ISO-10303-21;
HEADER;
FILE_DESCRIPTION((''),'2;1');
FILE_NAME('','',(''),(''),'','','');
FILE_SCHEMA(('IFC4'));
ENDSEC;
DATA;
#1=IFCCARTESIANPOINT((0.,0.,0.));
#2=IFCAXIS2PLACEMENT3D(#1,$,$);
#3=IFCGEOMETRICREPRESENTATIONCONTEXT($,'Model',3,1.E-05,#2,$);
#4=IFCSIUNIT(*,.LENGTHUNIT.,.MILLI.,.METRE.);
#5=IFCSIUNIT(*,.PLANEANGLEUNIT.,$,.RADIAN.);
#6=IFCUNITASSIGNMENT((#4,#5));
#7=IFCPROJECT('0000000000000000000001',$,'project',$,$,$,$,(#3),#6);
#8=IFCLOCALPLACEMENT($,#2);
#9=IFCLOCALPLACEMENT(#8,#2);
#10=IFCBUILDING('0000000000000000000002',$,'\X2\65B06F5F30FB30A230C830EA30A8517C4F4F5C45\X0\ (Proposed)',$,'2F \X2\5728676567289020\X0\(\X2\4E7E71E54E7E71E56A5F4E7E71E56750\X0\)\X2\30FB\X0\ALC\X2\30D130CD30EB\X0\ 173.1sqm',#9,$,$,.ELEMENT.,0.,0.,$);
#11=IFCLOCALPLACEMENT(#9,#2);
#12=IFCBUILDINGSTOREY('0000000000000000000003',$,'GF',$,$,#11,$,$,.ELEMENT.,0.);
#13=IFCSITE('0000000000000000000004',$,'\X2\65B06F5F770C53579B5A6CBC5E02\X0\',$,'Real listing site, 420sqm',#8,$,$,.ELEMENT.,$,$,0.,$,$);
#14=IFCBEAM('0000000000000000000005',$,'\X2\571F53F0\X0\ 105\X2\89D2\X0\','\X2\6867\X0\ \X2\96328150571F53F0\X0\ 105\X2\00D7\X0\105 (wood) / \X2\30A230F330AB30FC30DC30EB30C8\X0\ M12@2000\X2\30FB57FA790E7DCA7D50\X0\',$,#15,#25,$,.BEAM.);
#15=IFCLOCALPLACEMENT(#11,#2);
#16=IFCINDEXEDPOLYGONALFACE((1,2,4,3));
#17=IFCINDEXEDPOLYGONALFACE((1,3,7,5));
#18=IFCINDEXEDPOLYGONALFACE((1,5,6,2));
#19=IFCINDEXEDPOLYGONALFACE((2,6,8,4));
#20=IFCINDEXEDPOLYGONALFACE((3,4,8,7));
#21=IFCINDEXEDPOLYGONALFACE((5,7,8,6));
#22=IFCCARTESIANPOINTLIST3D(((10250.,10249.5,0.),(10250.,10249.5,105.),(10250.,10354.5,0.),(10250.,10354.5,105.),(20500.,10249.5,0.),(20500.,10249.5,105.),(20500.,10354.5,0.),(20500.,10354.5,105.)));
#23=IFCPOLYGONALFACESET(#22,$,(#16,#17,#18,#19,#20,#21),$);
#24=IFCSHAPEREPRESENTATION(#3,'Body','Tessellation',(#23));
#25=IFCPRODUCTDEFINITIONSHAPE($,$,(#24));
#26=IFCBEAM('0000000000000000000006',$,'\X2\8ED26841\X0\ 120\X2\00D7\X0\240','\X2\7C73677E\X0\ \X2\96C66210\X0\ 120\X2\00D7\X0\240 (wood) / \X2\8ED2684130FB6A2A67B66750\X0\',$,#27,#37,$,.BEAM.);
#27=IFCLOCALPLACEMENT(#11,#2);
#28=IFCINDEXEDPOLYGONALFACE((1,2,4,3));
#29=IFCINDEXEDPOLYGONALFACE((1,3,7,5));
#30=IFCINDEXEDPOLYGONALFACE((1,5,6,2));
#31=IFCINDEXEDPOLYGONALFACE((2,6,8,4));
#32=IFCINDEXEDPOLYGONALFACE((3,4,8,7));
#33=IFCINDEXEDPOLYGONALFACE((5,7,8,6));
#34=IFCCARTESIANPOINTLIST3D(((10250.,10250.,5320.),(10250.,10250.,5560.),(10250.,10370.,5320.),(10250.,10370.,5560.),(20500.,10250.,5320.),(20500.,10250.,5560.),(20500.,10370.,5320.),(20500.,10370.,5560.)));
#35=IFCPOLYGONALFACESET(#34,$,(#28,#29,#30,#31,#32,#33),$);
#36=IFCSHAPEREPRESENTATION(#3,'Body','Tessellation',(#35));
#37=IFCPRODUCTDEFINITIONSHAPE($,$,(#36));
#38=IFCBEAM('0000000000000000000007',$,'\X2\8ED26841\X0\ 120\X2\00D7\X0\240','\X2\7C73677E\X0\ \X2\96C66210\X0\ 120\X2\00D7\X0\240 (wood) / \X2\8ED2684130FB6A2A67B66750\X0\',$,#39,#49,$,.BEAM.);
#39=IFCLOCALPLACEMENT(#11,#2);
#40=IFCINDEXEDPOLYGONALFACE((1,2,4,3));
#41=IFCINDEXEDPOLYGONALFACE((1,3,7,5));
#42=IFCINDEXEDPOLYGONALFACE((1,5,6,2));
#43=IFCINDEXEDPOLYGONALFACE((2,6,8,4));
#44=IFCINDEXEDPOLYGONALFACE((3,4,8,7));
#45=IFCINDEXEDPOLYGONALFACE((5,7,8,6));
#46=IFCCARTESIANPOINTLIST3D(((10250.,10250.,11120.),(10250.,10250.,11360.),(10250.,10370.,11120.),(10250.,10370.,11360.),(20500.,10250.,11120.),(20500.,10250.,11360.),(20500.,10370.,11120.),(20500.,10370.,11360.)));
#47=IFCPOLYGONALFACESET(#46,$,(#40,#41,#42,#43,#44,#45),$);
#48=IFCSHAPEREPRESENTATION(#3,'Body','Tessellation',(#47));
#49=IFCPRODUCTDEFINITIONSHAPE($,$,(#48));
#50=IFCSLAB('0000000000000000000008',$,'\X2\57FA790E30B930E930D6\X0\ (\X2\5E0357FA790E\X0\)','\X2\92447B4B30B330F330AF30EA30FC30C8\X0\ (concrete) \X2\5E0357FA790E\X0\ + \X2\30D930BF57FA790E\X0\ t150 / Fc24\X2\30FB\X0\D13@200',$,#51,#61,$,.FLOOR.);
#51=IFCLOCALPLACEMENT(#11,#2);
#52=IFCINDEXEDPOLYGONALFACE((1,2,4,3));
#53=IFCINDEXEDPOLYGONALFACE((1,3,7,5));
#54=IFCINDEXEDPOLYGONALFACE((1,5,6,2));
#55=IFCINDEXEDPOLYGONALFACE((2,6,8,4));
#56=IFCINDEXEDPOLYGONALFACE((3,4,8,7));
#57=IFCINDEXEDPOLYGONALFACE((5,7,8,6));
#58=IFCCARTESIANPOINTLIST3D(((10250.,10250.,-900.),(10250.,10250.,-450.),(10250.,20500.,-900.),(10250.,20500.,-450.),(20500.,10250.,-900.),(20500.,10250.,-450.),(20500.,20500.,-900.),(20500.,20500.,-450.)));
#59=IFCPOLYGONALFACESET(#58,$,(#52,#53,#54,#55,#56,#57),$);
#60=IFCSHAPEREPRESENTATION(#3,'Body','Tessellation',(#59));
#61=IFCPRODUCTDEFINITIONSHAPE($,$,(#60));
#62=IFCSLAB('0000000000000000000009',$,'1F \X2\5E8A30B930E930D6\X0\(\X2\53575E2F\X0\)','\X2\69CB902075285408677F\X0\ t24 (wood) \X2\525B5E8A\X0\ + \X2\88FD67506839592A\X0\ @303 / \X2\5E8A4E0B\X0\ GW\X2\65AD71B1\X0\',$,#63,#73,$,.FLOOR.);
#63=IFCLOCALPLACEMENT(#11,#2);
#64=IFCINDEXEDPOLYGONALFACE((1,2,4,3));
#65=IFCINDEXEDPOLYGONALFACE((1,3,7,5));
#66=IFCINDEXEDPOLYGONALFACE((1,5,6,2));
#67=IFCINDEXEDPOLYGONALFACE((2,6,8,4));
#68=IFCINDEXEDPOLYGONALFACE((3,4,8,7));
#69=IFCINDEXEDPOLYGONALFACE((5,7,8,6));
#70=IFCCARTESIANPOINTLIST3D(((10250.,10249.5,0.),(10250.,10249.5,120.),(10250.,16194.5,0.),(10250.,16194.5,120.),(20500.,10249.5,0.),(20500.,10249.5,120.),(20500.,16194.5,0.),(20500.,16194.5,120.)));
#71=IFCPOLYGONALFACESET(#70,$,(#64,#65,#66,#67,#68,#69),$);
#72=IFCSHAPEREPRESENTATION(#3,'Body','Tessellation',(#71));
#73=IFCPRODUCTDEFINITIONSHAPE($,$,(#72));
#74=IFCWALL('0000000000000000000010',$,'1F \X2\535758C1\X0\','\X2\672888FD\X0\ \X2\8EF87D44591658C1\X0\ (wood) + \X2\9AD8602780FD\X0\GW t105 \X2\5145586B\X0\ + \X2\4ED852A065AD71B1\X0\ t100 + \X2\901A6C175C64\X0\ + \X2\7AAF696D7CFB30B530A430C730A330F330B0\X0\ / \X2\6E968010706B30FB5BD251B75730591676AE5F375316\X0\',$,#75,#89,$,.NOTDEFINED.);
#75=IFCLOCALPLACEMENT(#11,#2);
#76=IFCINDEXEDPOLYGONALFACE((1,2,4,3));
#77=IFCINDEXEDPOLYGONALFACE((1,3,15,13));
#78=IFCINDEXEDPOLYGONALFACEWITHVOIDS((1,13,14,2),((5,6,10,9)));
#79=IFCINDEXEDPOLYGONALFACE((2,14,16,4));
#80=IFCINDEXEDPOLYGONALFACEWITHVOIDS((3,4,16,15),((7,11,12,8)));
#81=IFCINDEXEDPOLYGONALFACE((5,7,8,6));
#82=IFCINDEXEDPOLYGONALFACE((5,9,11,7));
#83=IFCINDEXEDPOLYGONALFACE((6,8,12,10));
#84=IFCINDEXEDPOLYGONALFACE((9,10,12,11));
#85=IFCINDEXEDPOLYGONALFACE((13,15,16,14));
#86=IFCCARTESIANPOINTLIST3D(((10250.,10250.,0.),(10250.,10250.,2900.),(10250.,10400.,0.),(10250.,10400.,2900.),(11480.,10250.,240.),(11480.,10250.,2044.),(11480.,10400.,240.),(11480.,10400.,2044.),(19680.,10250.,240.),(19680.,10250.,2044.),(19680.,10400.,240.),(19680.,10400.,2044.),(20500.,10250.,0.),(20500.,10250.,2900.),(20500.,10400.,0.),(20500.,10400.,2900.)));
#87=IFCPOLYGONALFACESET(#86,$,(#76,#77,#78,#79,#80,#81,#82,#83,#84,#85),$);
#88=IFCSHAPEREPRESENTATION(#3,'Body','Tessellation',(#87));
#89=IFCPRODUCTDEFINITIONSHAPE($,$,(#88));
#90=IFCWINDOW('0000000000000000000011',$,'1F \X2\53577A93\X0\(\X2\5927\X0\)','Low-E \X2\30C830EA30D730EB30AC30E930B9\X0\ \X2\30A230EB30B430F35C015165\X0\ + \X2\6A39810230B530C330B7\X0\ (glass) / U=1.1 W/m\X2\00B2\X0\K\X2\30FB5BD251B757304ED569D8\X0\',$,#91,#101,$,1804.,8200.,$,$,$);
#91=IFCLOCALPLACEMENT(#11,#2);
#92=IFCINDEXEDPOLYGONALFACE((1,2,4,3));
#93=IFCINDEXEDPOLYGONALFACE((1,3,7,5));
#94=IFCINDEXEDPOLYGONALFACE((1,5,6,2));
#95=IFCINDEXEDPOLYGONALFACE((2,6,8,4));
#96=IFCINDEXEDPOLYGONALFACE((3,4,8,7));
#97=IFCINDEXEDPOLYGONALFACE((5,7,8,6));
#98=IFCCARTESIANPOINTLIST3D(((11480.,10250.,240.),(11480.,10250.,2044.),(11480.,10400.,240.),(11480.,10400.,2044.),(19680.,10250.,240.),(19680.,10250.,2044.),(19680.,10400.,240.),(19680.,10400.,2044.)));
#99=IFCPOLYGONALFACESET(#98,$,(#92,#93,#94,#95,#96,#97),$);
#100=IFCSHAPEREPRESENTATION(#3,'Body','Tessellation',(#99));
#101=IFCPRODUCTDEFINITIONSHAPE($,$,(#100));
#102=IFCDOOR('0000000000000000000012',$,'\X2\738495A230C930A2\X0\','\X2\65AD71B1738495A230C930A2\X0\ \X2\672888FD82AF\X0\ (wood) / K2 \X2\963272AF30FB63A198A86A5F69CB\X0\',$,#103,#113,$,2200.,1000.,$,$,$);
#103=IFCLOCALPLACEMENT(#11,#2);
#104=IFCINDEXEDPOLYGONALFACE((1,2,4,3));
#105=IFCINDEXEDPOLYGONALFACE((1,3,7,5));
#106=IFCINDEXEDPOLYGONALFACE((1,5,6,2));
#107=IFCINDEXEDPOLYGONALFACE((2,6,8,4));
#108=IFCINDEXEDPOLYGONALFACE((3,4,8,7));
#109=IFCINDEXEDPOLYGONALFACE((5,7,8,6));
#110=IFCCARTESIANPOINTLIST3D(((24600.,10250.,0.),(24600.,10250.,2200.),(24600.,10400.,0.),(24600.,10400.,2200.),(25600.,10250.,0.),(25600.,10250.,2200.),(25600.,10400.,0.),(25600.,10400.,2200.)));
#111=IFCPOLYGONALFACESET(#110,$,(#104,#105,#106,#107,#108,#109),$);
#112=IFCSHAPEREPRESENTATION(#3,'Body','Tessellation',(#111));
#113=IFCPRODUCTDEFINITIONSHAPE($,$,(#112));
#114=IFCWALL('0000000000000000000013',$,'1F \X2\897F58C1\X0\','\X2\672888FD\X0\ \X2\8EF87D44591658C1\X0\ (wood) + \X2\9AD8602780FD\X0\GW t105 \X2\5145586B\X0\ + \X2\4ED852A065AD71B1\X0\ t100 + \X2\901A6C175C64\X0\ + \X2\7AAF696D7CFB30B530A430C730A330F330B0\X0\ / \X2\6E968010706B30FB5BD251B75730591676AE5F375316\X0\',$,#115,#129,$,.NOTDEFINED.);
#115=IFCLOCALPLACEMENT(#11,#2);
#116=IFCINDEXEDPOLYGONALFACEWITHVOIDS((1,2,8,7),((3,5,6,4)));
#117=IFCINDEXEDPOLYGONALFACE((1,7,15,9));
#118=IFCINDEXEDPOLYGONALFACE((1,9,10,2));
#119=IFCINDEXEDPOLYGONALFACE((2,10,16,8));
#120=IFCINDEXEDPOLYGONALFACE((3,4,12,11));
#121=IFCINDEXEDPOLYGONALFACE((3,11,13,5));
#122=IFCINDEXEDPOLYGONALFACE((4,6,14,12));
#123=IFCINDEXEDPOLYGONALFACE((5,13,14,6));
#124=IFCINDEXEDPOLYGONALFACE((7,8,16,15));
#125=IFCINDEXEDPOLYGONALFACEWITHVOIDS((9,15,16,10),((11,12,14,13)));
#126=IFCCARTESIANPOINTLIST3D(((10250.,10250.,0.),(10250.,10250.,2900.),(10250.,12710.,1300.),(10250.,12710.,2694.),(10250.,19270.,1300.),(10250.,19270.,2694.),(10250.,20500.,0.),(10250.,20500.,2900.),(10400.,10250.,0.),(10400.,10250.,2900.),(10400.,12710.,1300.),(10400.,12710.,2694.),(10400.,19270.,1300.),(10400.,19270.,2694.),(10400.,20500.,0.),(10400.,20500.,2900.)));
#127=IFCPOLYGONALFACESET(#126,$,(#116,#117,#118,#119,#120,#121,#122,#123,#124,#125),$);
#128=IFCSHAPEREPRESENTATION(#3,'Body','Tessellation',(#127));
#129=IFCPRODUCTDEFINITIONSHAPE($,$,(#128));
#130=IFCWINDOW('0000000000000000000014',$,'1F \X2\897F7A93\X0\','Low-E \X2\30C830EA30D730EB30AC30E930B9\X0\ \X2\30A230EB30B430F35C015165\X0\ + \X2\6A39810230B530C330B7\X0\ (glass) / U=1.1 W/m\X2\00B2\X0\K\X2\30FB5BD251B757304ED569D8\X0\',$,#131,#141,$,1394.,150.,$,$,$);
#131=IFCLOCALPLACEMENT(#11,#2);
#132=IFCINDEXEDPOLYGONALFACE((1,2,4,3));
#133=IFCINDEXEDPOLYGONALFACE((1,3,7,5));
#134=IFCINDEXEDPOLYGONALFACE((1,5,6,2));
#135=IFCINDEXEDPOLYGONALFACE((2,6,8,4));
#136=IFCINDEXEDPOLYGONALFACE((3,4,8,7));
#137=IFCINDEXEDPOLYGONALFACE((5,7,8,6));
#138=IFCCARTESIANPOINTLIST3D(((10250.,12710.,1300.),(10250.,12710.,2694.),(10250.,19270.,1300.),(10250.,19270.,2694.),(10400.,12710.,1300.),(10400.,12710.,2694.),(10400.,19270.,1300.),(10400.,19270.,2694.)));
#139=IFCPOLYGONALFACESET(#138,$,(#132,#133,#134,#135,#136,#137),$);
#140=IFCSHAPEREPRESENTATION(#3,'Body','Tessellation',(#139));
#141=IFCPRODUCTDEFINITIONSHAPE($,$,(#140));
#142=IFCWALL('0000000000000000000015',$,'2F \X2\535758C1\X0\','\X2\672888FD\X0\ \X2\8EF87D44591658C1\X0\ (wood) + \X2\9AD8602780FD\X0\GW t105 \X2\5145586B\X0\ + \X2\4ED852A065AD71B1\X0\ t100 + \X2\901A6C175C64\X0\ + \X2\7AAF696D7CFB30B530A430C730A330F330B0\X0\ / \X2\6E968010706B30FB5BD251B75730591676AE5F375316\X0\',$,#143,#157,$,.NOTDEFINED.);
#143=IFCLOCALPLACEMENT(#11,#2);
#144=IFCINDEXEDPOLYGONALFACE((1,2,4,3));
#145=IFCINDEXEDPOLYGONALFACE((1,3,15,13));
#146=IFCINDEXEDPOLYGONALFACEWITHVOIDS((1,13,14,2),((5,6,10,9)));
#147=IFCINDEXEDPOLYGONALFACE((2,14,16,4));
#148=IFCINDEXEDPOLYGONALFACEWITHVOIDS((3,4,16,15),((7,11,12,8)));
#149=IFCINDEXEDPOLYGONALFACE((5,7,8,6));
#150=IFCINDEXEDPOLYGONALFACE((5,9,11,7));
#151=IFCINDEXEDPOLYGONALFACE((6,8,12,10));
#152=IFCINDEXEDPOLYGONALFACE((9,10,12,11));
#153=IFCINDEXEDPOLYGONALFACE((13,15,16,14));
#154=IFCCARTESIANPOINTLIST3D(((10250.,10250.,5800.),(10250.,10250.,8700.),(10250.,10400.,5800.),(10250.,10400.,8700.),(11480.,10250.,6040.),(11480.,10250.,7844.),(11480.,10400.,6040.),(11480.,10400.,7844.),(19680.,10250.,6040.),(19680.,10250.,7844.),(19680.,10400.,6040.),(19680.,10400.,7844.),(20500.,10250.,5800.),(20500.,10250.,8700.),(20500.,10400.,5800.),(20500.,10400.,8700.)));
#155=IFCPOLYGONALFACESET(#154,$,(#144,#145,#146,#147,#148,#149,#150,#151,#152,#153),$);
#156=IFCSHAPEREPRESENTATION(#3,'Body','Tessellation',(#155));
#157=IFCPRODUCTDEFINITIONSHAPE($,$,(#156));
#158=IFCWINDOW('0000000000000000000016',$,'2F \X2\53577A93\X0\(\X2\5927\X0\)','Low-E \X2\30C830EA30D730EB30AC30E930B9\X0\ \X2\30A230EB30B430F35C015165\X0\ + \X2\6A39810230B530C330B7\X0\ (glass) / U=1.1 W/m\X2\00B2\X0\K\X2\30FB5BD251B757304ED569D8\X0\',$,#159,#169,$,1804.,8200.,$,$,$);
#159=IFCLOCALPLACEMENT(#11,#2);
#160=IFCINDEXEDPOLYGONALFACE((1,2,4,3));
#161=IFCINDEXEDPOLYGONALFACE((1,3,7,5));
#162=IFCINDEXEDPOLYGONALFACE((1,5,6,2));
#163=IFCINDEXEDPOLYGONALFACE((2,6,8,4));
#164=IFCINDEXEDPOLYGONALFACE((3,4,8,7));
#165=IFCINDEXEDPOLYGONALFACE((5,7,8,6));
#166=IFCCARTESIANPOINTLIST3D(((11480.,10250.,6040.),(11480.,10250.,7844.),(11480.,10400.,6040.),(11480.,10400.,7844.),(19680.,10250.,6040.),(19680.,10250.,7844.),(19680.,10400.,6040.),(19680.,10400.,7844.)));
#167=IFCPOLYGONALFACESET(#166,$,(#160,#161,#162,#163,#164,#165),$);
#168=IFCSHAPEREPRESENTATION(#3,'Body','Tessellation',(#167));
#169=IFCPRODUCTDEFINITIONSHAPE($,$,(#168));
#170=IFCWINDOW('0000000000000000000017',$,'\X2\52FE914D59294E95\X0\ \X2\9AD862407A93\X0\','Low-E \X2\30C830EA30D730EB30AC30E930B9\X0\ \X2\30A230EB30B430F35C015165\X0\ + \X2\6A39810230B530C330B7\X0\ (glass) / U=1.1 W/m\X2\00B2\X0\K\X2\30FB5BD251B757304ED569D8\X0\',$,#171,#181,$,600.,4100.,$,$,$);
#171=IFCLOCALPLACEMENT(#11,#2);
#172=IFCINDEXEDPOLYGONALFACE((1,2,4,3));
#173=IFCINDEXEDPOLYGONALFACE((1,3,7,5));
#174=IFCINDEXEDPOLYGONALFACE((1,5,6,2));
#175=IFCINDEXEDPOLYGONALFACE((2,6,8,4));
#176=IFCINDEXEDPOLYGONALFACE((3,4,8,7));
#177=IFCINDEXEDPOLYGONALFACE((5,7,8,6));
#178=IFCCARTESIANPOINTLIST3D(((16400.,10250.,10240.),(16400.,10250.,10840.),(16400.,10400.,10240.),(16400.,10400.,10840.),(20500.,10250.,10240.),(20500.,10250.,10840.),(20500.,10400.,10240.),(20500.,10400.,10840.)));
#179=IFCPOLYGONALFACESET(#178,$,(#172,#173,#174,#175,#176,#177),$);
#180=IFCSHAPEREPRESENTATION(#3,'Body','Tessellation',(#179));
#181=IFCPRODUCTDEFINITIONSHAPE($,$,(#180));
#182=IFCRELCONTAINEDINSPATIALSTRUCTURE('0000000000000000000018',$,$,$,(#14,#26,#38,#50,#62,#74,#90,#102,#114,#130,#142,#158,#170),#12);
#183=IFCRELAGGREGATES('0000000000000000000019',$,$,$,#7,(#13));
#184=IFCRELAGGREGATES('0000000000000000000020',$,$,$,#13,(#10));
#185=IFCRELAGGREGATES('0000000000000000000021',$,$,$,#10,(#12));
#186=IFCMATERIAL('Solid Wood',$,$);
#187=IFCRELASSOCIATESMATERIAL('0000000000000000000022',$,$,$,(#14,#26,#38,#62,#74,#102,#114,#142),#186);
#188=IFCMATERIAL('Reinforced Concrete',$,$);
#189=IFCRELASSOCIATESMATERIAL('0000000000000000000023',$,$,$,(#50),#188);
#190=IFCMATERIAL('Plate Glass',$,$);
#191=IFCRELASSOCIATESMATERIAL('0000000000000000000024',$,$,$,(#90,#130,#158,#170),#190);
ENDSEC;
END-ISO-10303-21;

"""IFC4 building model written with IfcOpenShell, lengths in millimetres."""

from ifc_helpers import new_model, si_unit, frame, frame_2d, origin, place, context, project, spatial, rectangle, extrude, material, element, fill, save


model = new_model("IFC4")

# Units and contexts
model_context = context("Model", 3, precision=1e-05, world=origin())
ifc_project = project(units=[si_unit("LENGTHUNIT", "METRE", prefix="MILLI"), si_unit("PLANEANGLEUNIT", "RADIAN")], contexts=[model_context])

# Site, building, storey
site_placement = place(None, origin())
site = spatial("IfcSite", under=ifc_project, at=site_placement, Name="新潟県南魚沼市", ObjectType="Real listing site, 420sqm", CompositionType="ELEMENT", RefElevation=0.0)
building_placement = place(site_placement, origin())
building = spatial("IfcBuilding", under=site, at=building_placement, Name="新潟・アトリエ兼住居 (Proposed)", ObjectType="2F 在来木造(乾燥乾燥機乾燥材)・ALCパネル 173.1sqm", CompositionType="ELEMENT", ElevationOfRefHeight=0.0, ElevationOfTerrain=0.0)
storey_placement = place(building_placement, origin())
storey = spatial("IfcBuildingStorey", under=building, at=storey_placement, Name="GF", CompositionType="ELEMENT", Elevation=0.0)

# Shared definitions
ifc_material_1 = material(Name="Solid Wood")

# Beams
beam_1_placement = place(storey_placement, frame((5125.0, 5125.0, 0.0)))
element("IfcBeam", 1, at=beam_1_placement, inside=storey, material=ifc_material_1, Name="土台 105角", Description="桧 防腐土台 105×105 (wood) / アンカーボルト M12@2000・基礎緊結", PredefinedType="BEAM", context=model_context, shape_type="SweptSolid", body=[
    extrude(rectangle(XDim=10250.0, YDim=105.0, at=frame_2d((5125.0, 52.0))), frame((5125.0, 5125.0, 0.0)), (0.0, 0.0, 1.0), 105.0),
])
beam_2_placement = place(storey_placement, frame((5125.0, 5125.0, 2660.0)))
element("IfcBeam", 2, at=beam_2_placement, inside=storey, material=ifc_material_1, Name="軒桁 120×240", Description="米松 集成 120×240 (wood) / 軒桁・横架材", PredefinedType="BEAM", context=model_context, shape_type="SweptSolid", body=[
    extrude(rectangle(XDim=10250.0, YDim=120.0, at=frame_2d((5125.0, 60.0))), frame((5125.0, 5125.0, 2660.0)), (0.0, 0.0, 1.0), 240.0),
])
beam_3_placement = place(storey_placement, frame((5125.0, 5125.0, 5560.0)))
element("IfcBeam", 3, at=beam_3_placement, inside=storey, material=ifc_material_1, Name="軒桁 120×240", Description="米松 集成 120×240 (wood) / 軒桁・横架材", PredefinedType="BEAM", context=model_context, shape_type="SweptSolid", body=[
    extrude(rectangle(XDim=10250.0, YDim=120.0, at=frame_2d((5125.0, 60.0))), frame((5125.0, 5125.0, 5560.0)), (0.0, 0.0, 1.0), 240.0),
])

# Slabs
ifc_material_2 = material(Name="Reinforced Concrete")
slab_1_placement = place(storey_placement, frame((5125.0, 5125.0, -450.0)))
element("IfcSlab", 4, at=slab_1_placement, inside=storey, material=ifc_material_2, Name="基礎スラブ (布基礎)", Description="鉄筋コンクリート (concrete) 布基礎 + ベタ基礎 t150 / Fc24・D13@200", PredefinedType="FLOOR", context=model_context, shape_type="SweptSolid", body=[
    extrude(rectangle(XDim=10250.0, YDim=10250.0, at=frame_2d((5125.0, 5125.0))), frame((5125.0, 5125.0, -450.0)), (0.0, 0.0, 1.0), 450.0),
])
slab_2_placement = place(storey_placement, frame((5125.0, 5125.0, 0.0)))
element("IfcSlab", 5, at=slab_2_placement, inside=storey, material=ifc_material_1, Name="1F 床スラブ(南帯)", Description="構造用合板 t24 (wood) 剛床 + 製材根太 @303 / 床下 GW断熱", PredefinedType="FLOOR", context=model_context, shape_type="SweptSolid", body=[
    extrude(rectangle(XDim=10250.0, YDim=5945.0, at=frame_2d((5125.0, 2972.0))), frame((5125.0, 5125.0, 0.0)), (0.0, 0.0, 1.0), 120.0),
])

# Wall, openings, window, door
wall_1_placement = place(storey_placement, frame((5125.0, 5125.0, 0.0)))
wall_1 = element("IfcWall", 6, at=wall_1_placement, inside=storey, material=ifc_material_1, Name="1F 南壁", Description="木製 軸組外壁 (wood) + 高性能GW t105 充填 + 付加断熱 t100 + 通気層 + 窯業系サイディング / 準耐火・寒冷地外皮強化", PredefinedType="NOTDEFINED", context=model_context, shape_type="SweptSolid", body=[
    extrude(rectangle(XDim=10250.0, YDim=150.0, at=frame_2d((5125.0, 75.0))), frame((5125.0, 5125.0, 0.0)), (0.0, 0.0, 1.0), 2900.0),
])
opening_1_placement = place(storey_placement, frame((5740.0, 5125.0, 120.0)))
opening_1 = element("IfcOpeningElement", 7, at=opening_1_placement, cuts=wall_1, PredefinedType="NOTDEFINED", context=model_context, shape_type="SweptSolid", body=[
    extrude(rectangle(XDim=8200.0, YDim=150.0, at=frame_2d((4100.0, 75.0))), frame((5740.0, 5125.0, 120.0)), (0.0, 0.0, 1.0), 1804.0),
])
opening_2_placement = place(storey_placement, frame((12300.0, 5125.0, 0.0)))
opening_2 = element("IfcOpeningElement", 8, at=opening_2_placement, cuts=wall_1, PredefinedType="NOTDEFINED", context=model_context, shape_type="SweptSolid", body=[
    extrude(rectangle(XDim=1000.0, YDim=150.0, at=frame_2d((500.0, 75.0))), frame((12300.0, 5125.0, 0.0)), (0.0, 0.0, 1.0), 2200.0),
])
ifc_material_3 = material(Name="Plate Glass")
window_1_placement = place(storey_placement, frame((5740.0, 5125.0, 120.0)))
window_1 = element("IfcWindow", 9, at=window_1_placement, inside=storey, material=ifc_material_3, Name="1F 南窓(大)", Description="Low-E トリプルガラス アルゴン封入 + 樹脂サッシ (glass) / U=1.1 W/m²K・寒冷地仕様", OverallHeight=1804.0, OverallWidth=8200.0, context=model_context, shape_type="SweptSolid", body=[
    extrude(rectangle(XDim=8200.0, YDim=150.0, at=frame_2d((4100.0, 75.0))), frame((5740.0, 5125.0, 120.0)), (0.0, 0.0, 1.0), 1804.0),
])
fill(opening_1, window_1)
door_placement = place(storey_placement, frame((12300.0, 5125.0, 0.0)))
door = element("IfcDoor", 10, at=door_placement, inside=storey, material=ifc_material_1, Name="玄関ドア", Description="断熱玄関ドア 木製芯 (wood) / K2 防犯・採風機構", OverallHeight=2200.0, OverallWidth=1000.0, context=model_context, shape_type="SweptSolid", body=[
    extrude(rectangle(XDim=1000.0, YDim=150.0, at=frame_2d((500.0, 75.0))), frame((12300.0, 5125.0, 0.0)), (0.0, 0.0, 1.0), 2200.0),
])
fill(opening_2, door)

# Wall, opening, window
wall_2_placement = place(storey_placement, frame((5125.0, 5125.0, 0.0)))
wall_2 = element("IfcWall", 11, at=wall_2_placement, inside=storey, material=ifc_material_1, Name="1F 西壁", Description="木製 軸組外壁 (wood) + 高性能GW t105 充填 + 付加断熱 t100 + 通気層 + 窯業系サイディング / 準耐火・寒冷地外皮強化", PredefinedType="NOTDEFINED", context=model_context, shape_type="SweptSolid", body=[
    extrude(rectangle(XDim=150.0, YDim=10250.0, at=frame_2d((75.0, 5125.0))), frame((5125.0, 5125.0, 0.0)), (0.0, 0.0, 1.0), 2900.0),
])
opening_3_placement = place(storey_placement, frame((5125.0, 6355.0, 650.0)))
opening_3 = element("IfcOpeningElement", 12, at=opening_3_placement, cuts=wall_2, PredefinedType="NOTDEFINED", context=model_context, shape_type="SweptSolid", body=[
    extrude(rectangle(XDim=150.0, YDim=6560.0, at=frame_2d((75.0, 3280.0))), frame((5125.0, 6355.0, 650.0)), (0.0, 0.0, 1.0), 1394.0),
])
window_2_placement = place(storey_placement, frame((5125.0, 6355.0, 650.0)))
window_2 = element("IfcWindow", 13, at=window_2_placement, inside=storey, material=ifc_material_3, Name="1F 西窓", Description="Low-E トリプルガラス アルゴン封入 + 樹脂サッシ (glass) / U=1.1 W/m²K・寒冷地仕様", OverallHeight=1394.0, OverallWidth=150.0, context=model_context, shape_type="SweptSolid", body=[
    extrude(rectangle(XDim=150.0, YDim=6560.0, at=frame_2d((75.0, 3280.0))), frame((5125.0, 6355.0, 650.0)), (0.0, 0.0, 1.0), 1394.0),
])
fill(opening_3, window_2)

# Wall, openings, windows
wall_3_placement = place(storey_placement, frame((5125.0, 5125.0, 2900.0)))
wall_3 = element("IfcWall", 14, at=wall_3_placement, inside=storey, material=ifc_material_1, Name="2F 南壁", Description="木製 軸組外壁 (wood) + 高性能GW t105 充填 + 付加断熱 t100 + 通気層 + 窯業系サイディング / 準耐火・寒冷地外皮強化", PredefinedType="NOTDEFINED", context=model_context, shape_type="SweptSolid", body=[
    extrude(rectangle(XDim=10250.0, YDim=150.0, at=frame_2d((5125.0, 75.0))), frame((5125.0, 5125.0, 2900.0)), (0.0, 0.0, 1.0), 2900.0),
])
opening_4_placement = place(storey_placement, frame((5740.0, 5125.0, 3020.0)))
opening_4 = element("IfcOpeningElement", 15, at=opening_4_placement, cuts=wall_3, PredefinedType="NOTDEFINED", context=model_context, shape_type="SweptSolid", body=[
    extrude(rectangle(XDim=8200.0, YDim=150.0, at=frame_2d((4100.0, 75.0))), frame((5740.0, 5125.0, 3020.0)), (0.0, 0.0, 1.0), 1804.0),
])
opening_5_placement = place(storey_placement, frame((8200.0, 5125.0, 5120.0)))
opening_5 = element("IfcOpeningElement", 16, at=opening_5_placement, cuts=wall_3, PredefinedType="NOTDEFINED", context=model_context, shape_type="SweptSolid", body=[
    extrude(rectangle(XDim=4100.0, YDim=150.0, at=frame_2d((2050.0, 75.0))), frame((8200.0, 5125.0, 5120.0)), (0.0, 0.0, 1.0), 600.0),
])
window_3_placement = place(storey_placement, frame((5740.0, 5125.0, 3020.0)))
window_3 = element("IfcWindow", 17, at=window_3_placement, inside=storey, material=ifc_material_3, Name="2F 南窓(大)", Description="Low-E トリプルガラス アルゴン封入 + 樹脂サッシ (glass) / U=1.1 W/m²K・寒冷地仕様", OverallHeight=1804.0, OverallWidth=8200.0, context=model_context, shape_type="SweptSolid", body=[
    extrude(rectangle(XDim=8200.0, YDim=150.0, at=frame_2d((4100.0, 75.0))), frame((5740.0, 5125.0, 3020.0)), (0.0, 0.0, 1.0), 1804.0),
])
fill(opening_4, window_3)
window_4_placement = place(storey_placement, frame((8200.0, 5125.0, 5120.0)))
window_4 = element("IfcWindow", 18, at=window_4_placement, inside=storey, material=ifc_material_3, Name="勾配天井 高所窓", Description="Low-E トリプルガラス アルゴン封入 + 樹脂サッシ (glass) / U=1.1 W/m²K・寒冷地仕様", OverallHeight=600.0, OverallWidth=4100.0, context=model_context, shape_type="SweptSolid", body=[
    extrude(rectangle(XDim=4100.0, YDim=150.0, at=frame_2d((2050.0, 75.0))), frame((8200.0, 5125.0, 5120.0)), (0.0, 0.0, 1.0), 600.0),
])
fill(opening_5, window_4)

save(model, "model.ifc")
